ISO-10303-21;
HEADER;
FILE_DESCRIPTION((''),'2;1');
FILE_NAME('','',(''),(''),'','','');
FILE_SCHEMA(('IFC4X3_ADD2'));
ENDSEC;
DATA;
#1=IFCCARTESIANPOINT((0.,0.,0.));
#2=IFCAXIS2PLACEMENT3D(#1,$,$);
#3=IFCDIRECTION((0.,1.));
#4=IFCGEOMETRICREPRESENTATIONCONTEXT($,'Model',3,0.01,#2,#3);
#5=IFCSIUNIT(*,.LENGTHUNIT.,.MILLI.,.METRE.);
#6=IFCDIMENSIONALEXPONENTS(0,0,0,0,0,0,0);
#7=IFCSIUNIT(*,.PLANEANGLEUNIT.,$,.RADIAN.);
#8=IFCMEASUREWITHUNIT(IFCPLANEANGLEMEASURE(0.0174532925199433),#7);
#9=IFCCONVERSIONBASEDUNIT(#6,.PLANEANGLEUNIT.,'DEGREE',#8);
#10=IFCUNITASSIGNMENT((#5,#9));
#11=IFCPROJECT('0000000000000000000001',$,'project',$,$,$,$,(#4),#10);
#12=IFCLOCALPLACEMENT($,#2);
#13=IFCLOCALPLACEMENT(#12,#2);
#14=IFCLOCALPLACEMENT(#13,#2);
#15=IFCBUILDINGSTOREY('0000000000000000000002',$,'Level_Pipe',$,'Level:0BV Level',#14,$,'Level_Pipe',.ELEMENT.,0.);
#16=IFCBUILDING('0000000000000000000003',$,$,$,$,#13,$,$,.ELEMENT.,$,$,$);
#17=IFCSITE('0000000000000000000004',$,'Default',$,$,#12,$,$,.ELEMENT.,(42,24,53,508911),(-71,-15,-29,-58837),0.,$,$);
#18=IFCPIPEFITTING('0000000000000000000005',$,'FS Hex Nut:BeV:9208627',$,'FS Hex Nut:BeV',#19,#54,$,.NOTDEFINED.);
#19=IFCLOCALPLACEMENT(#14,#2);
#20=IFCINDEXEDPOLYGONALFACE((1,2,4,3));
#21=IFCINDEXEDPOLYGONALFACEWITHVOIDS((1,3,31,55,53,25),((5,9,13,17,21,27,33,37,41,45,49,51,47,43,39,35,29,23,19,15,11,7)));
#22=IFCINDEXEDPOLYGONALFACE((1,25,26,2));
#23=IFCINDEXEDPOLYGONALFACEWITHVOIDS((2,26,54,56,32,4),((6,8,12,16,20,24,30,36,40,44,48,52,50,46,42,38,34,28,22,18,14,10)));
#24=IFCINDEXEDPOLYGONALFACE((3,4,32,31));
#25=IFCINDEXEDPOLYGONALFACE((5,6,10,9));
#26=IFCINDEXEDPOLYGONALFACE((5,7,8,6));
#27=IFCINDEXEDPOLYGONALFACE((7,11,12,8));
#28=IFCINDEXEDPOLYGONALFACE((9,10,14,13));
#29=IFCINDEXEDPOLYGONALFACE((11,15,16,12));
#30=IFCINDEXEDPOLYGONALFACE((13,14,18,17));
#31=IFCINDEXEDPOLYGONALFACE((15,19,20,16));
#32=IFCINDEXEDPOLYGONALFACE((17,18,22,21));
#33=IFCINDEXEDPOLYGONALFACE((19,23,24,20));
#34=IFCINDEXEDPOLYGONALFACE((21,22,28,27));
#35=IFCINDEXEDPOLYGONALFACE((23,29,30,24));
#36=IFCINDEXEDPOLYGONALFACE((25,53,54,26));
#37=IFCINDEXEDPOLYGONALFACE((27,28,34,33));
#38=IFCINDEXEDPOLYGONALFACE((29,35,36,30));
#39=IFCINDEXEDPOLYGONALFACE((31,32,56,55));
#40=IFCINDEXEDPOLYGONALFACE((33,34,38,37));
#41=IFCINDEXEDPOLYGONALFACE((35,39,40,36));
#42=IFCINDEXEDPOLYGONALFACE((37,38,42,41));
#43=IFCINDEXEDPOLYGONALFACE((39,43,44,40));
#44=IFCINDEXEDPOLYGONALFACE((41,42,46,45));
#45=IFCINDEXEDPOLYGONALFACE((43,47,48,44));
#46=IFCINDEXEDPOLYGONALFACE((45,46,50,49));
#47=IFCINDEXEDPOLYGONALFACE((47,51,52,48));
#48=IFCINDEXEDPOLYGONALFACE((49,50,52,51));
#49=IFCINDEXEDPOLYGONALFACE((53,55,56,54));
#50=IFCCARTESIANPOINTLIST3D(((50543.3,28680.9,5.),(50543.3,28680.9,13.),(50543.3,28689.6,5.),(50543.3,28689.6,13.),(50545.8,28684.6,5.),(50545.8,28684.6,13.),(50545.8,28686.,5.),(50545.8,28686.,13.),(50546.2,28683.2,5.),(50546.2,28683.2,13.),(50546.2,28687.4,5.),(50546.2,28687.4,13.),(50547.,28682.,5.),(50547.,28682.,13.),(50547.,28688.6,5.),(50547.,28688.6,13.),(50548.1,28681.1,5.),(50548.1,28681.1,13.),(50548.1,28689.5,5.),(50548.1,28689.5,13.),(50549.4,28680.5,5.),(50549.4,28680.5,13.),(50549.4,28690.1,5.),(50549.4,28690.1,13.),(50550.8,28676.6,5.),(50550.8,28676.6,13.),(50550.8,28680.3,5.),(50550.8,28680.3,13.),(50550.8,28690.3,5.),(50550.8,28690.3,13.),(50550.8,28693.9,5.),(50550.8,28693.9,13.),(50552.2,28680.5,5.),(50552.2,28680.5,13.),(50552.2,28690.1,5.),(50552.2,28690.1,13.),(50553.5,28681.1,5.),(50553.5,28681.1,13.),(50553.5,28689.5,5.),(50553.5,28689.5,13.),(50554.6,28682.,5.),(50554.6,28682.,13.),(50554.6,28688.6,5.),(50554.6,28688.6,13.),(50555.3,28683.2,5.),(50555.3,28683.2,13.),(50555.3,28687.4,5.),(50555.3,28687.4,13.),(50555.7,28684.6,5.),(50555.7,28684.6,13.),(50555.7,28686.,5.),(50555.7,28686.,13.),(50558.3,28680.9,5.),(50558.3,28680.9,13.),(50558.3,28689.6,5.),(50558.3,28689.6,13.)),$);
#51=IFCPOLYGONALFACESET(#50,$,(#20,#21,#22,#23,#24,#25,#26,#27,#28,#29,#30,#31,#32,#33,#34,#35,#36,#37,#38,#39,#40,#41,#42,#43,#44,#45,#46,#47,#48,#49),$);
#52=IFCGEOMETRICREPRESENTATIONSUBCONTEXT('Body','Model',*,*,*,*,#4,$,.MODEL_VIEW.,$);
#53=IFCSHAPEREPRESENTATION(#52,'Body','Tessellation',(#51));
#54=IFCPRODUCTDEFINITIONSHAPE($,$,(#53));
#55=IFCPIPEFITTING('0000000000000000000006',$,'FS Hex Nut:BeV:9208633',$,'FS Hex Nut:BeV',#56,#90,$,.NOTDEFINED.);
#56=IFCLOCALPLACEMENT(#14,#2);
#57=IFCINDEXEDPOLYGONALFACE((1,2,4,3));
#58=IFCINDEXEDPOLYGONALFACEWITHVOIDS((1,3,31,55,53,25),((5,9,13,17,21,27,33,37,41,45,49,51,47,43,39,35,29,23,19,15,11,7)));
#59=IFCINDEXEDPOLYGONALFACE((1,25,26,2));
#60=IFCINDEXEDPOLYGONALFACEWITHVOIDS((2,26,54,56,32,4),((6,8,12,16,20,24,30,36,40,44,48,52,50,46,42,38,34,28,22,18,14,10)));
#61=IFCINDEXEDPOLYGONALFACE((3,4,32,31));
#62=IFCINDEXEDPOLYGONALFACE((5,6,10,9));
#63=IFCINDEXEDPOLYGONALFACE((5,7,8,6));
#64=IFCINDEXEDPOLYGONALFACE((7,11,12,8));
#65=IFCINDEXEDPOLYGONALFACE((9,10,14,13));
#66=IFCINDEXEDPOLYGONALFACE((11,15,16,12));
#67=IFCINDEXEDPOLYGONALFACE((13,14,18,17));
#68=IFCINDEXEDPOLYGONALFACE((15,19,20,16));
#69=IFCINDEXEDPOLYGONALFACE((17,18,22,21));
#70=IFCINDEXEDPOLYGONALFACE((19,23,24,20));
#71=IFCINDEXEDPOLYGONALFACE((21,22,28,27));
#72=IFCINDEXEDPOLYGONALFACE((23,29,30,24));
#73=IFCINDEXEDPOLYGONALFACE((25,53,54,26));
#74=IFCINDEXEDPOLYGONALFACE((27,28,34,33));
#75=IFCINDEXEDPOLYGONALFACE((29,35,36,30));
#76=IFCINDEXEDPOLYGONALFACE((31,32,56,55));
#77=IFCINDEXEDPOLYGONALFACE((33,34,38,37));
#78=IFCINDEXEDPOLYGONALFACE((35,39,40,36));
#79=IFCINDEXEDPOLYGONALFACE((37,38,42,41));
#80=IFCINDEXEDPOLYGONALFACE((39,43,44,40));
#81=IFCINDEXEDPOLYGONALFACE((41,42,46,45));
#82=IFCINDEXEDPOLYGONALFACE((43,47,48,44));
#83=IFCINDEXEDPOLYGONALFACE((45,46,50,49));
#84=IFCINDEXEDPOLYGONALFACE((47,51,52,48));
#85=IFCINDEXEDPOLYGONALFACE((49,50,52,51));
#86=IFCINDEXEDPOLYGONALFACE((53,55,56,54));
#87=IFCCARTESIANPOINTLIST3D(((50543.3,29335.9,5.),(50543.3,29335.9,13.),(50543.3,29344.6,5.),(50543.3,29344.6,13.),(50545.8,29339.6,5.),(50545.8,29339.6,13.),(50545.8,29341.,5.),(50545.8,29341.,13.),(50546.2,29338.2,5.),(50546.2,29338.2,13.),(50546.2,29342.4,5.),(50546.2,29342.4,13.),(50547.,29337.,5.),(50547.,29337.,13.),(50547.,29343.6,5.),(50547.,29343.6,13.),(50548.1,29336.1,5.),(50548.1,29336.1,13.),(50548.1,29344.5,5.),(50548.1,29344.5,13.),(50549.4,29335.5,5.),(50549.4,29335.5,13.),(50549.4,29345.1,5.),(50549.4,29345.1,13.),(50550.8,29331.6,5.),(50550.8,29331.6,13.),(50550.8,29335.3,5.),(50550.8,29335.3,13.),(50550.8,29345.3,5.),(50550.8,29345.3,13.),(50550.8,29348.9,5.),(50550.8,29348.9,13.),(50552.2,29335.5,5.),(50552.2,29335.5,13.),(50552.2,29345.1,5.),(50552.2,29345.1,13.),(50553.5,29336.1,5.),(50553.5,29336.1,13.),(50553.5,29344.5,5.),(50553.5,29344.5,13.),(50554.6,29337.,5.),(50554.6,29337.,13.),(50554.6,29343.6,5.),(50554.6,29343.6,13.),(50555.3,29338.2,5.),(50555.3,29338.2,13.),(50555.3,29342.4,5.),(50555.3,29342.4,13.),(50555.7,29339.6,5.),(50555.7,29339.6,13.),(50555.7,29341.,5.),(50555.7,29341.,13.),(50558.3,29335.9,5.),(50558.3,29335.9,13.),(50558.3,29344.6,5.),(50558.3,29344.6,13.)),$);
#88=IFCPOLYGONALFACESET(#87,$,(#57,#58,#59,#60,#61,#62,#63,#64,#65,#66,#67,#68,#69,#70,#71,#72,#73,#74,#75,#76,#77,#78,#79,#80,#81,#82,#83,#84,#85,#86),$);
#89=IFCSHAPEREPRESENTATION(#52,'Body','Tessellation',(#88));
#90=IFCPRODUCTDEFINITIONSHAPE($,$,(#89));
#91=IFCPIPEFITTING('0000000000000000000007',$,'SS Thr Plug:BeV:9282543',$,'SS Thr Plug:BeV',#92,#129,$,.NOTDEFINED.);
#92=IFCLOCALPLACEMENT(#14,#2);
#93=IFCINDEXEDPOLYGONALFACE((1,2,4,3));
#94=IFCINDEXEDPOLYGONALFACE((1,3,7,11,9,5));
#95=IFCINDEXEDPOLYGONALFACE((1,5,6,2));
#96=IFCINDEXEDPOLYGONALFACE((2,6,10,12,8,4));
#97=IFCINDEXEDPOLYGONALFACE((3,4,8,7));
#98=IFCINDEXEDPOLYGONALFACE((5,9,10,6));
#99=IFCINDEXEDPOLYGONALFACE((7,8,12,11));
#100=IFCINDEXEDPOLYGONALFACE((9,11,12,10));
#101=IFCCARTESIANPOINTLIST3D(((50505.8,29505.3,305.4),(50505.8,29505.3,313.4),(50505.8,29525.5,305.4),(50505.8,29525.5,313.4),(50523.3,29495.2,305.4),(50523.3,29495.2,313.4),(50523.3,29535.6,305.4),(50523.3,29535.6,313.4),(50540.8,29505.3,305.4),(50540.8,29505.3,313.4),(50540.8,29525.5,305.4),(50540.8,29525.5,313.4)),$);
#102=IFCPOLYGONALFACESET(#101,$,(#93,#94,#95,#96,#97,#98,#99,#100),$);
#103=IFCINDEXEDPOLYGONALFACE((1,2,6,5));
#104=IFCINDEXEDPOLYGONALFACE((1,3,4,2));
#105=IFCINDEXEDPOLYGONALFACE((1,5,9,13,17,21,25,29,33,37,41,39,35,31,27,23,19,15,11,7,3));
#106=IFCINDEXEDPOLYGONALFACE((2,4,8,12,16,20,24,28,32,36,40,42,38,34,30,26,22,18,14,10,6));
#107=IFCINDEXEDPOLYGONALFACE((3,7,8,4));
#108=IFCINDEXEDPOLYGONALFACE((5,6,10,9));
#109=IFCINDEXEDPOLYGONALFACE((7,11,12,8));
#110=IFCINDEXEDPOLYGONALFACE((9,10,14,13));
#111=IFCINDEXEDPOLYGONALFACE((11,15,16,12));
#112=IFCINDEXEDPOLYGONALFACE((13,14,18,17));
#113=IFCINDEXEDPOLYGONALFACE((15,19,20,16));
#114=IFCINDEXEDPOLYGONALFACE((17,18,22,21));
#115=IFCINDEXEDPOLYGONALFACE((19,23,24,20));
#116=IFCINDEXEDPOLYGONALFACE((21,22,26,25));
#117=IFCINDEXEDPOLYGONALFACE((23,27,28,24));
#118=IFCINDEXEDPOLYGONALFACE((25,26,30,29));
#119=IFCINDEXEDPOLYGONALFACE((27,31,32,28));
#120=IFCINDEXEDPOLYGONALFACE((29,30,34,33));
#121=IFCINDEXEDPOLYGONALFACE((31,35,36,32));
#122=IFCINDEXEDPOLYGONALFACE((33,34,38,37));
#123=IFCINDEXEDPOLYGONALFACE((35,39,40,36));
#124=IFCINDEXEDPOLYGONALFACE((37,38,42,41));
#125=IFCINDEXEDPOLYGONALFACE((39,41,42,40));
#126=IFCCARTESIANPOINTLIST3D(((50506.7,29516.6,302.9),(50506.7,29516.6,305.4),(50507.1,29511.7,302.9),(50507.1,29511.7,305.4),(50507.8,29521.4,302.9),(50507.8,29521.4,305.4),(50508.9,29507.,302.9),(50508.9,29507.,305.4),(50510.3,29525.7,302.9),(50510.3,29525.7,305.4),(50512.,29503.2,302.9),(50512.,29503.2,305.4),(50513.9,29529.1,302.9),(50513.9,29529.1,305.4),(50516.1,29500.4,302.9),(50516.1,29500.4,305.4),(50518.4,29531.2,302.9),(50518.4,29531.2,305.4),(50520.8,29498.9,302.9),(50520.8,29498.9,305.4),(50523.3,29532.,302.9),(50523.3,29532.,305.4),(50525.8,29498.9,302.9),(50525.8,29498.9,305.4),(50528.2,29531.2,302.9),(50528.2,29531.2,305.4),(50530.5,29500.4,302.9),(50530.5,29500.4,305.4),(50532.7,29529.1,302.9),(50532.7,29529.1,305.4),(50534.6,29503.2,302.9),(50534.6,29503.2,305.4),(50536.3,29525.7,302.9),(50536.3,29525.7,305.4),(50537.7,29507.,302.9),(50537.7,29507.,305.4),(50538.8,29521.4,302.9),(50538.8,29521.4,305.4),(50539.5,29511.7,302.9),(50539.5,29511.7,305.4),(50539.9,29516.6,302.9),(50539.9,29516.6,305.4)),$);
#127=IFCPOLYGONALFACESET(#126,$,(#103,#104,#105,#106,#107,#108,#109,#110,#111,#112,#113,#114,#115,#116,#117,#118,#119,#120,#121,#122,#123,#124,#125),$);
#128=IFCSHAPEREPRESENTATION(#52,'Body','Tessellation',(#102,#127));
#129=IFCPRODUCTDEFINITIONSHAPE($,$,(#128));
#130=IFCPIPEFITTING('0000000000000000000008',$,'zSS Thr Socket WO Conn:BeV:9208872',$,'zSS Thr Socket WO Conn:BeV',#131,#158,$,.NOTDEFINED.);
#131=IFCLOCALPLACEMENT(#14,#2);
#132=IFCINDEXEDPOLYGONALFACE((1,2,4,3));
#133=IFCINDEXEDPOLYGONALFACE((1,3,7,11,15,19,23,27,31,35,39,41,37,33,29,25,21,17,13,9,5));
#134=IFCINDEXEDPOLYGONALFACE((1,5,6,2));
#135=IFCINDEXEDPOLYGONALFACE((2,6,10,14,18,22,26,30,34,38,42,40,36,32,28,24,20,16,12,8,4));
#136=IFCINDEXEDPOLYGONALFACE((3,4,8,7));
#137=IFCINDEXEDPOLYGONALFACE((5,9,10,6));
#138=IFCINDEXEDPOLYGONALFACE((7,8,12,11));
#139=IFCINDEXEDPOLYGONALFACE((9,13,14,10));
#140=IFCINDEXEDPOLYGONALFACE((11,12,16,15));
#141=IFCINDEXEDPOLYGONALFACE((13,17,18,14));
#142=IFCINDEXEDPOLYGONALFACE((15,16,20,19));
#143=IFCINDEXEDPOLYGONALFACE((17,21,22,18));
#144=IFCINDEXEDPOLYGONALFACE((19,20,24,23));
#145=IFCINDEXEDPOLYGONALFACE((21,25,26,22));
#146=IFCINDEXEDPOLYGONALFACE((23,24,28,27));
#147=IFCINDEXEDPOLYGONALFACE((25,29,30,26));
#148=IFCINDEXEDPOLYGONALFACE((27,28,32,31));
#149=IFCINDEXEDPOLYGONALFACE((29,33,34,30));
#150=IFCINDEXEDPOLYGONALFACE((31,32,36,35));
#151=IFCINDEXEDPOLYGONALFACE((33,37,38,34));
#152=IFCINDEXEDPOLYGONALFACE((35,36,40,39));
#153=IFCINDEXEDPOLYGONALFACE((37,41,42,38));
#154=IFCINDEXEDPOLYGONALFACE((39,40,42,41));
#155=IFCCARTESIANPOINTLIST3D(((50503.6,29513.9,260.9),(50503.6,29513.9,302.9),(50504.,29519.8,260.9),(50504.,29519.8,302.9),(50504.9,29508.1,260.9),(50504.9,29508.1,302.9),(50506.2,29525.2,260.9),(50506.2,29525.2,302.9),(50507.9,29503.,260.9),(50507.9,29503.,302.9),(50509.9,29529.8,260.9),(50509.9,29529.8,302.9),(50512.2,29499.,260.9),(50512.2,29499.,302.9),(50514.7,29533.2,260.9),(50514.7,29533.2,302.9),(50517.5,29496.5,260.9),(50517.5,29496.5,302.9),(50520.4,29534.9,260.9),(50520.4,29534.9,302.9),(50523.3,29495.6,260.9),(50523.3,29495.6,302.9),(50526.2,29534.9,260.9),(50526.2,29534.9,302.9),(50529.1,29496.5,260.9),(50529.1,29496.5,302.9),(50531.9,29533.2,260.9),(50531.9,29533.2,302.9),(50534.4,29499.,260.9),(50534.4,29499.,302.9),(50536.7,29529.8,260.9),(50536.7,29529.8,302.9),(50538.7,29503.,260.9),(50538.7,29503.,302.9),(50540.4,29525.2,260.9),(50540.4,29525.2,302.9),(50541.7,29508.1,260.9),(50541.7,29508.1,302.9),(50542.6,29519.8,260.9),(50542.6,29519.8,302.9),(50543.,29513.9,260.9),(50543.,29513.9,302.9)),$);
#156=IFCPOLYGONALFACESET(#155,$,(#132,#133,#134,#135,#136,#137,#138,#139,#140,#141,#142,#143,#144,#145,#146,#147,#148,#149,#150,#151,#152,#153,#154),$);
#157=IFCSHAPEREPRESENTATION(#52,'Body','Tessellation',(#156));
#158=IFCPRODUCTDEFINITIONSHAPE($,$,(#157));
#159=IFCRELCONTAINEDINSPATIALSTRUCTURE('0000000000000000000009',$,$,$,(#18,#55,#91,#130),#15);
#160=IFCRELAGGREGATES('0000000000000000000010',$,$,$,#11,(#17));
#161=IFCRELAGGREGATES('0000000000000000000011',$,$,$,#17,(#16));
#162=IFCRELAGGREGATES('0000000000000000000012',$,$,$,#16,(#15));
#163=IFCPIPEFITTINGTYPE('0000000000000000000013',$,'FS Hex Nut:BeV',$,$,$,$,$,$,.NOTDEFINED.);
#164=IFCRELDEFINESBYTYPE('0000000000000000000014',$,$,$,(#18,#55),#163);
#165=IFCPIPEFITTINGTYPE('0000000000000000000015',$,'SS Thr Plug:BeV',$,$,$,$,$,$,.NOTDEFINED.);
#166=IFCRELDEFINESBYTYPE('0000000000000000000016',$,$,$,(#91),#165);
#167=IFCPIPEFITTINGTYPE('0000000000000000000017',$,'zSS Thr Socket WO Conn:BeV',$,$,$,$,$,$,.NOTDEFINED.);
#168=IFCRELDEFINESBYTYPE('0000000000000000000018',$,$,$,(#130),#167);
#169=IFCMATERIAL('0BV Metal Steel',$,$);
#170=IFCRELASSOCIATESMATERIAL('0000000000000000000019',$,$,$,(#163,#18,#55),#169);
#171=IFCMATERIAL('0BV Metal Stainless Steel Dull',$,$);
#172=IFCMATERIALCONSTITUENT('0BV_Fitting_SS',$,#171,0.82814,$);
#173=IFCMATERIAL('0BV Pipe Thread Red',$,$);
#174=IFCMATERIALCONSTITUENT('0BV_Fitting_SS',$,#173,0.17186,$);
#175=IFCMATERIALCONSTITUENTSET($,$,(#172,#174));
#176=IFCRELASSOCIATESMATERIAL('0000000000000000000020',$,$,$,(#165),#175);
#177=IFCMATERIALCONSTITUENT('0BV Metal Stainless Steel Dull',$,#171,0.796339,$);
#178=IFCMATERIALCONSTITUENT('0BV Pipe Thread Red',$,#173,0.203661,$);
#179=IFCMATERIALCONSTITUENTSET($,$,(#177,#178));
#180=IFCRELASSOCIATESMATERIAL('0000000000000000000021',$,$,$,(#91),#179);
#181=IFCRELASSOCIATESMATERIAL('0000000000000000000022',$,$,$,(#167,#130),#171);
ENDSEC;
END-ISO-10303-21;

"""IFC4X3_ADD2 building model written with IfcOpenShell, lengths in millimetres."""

from ifc_helpers import new_model, entity, si_unit, converted_unit, direction, frame, frame_2d, origin, place, context, subcontext, project, spatial, polyline, circle_curve, parameter, trimmed, segment, composite_curve, circle, outline, extrude, source, transform, mapped, material, constituent, constituent_set, type_object, type_shapes, element, save


model = new_model("IFC4X3_ADD2")

# Units and contexts
model_context = context("Model", 3, precision=0.01, world=origin(), true_north=direction((0.0, 1.0)))
body_context = subcontext(model_context, "Body", "Model", "MODEL_VIEW")
ifc_project = project(units=[si_unit("LENGTHUNIT", "METRE", prefix="MILLI"), converted_unit("PLANEANGLEUNIT", "DEGREE", entity("IfcPlaneAngleMeasure", 0.0174532925199433), si_unit("PLANEANGLEUNIT", "RADIAN"), dimensions=[0, 0, 0, 0, 0, 0, 0])], contexts=[model_context])

# Site, building, storey
site_placement = place(None, origin())
site = spatial("IfcSite", under=ifc_project, at=site_placement, Name="Default", CompositionType="ELEMENT", RefLatitude=(42, 24, 53, 508911), RefLongitude=(-71, -15, -29, -58837), RefElevation=0.0)
building_placement = place(site_placement, origin())
building = spatial("IfcBuilding", under=site, at=building_placement, CompositionType="ELEMENT")
storey_placement = place(building_placement, origin())
storey = spatial("IfcBuildingStorey", under=building, at=storey_placement, Name="Level_Pipe", ObjectType="Level:0BV Level", LongName="Level_Pipe", CompositionType="ELEMENT", Elevation=0.0)

# Pipe fittings
ifc_material_1 = material(Name="0BV Metal Stainless Steel Dull")
ifc_material_2 = material(Name="0BV Metal Steel")
ifc_material_3 = material(Name="0BV Pipe Thread Red")
pipe_fitting_type_1 = type_object("IfcPipeFittingType", Name="FS Hex Nut:BeV", PredefinedType="NOTDEFINED", material=ifc_material_2)
shared_shape_1 = source(origin(), body_context, "Body", "SweptSolid", [
    extrude(outline(polyline([(-4.3, -7.5), (4.3, -7.5), (8.7, 0.0), (4.3, 7.5), (-4.3, 7.5), (-8.7, 0.0), (-4.3, -7.5)]), holes=[composite_curve([segment(trimmed(circle_curve(frame_2d((0.0, 0.0), x_axis=(-0.5, 0.866025)), 5.0), [parameter(0.0)], [parameter(180.0)], True, "PARAMETER"), False, "CONTINUOUS"), segment(trimmed(circle_curve(frame_2d((0.0, 0.0), x_axis=(-0.5, 0.866025)), 5.0), [parameter(180.0)], [parameter(360.0)], True, "PARAMETER"), False, "CONTINUOUS")], self_intersect=False)]), frame((0.0, 8.7, 7.5), z_axis=(1.0, 0.0, 0.0), x_axis=(0.0, -0.5, -0.866025)), (0.0, 0.0, 1.0), 8.0),
])
type_shapes(pipe_fitting_type_1, [shared_shape_1])
for number, where, z_axis, x_axis, name in (
    (1, (50558.3, 28693.9, 13.0), (-1.0, 0.0, 0.0), (0.0, 0.0, -1.0), "FS Hex Nut:BeV:9208627"),
    (2, (50558.3, 29348.9, 13.0), (-1.0, 0.0, 0.0), (0.0, 0.0, -1.0), "FS Hex Nut:BeV:9208633"),
):
    element("IfcPipeFitting", number, at=place(storey_placement, frame(where, z_axis=z_axis, x_axis=x_axis)), inside=storey, type_object=pipe_fitting_type_1, material=ifc_material_2, Name=name, ObjectType="FS Hex Nut:BeV", PredefinedType="NOTDEFINED", context=body_context, shape_type="MappedRepresentation", body=[
        mapped(shared_shape_1, transform((0.0, 0.0, 0.0), scale=1.0)),
    ])
ifc_constituent_1 = constituent(ifc_material_1, Name="0BV Metal Stainless Steel Dull", fraction=0.796339)
ifc_constituent_2 = constituent(ifc_material_3, Name="0BV Pipe Thread Red", fraction=0.203661)
ifc_constituent_set_1 = constituent_set(constituents=[ifc_constituent_1, ifc_constituent_2])
ifc_constituent_3 = constituent(ifc_material_1, Name="0BV_Fitting_SS", fraction=0.82814)
ifc_constituent_4 = constituent(ifc_material_3, Name="0BV_Fitting_SS", fraction=0.17186)
ifc_constituent_set_2 = constituent_set(constituents=[ifc_constituent_3, ifc_constituent_4])
pipe_fitting_type_2 = type_object("IfcPipeFittingType", Name="SS Thr Plug:BeV", PredefinedType="NOTDEFINED", material=ifc_constituent_set_2)
shared_shape_2 = source(origin(), body_context, "Body", "SweptSolid", [
    extrude(outline(polyline([(-10.1, -17.5), (10.1, -17.5), (20.2, 0.0), (10.1, 17.5), (-10.1, 17.5), (-20.2, 0.0), (-10.1, -17.5)])), frame((2.5, 0.0, 0.0), z_axis=(1.0, 0.0, 0.0), x_axis=(0.0, -0.5, -0.866025)), (0.0, 0.0, 1.0), 8.0),
    extrude(circle(Radius=16.6, at=frame_2d((0.0, 0.0), x_axis=(1.0, 0.0))), frame((0.0, 0.0, 0.0), z_axis=(1.0, 0.0, 0.0), x_axis=(0.0, 1.0, 0.0)), (0.0, 0.0, 1.0), 2.5),
])
type_shapes(pipe_fitting_type_2, [shared_shape_2])
pipe_fitting_1_placement = place(storey_placement, frame((50523.3, 29515.4, 302.9), z_axis=(-1.0, 0.0, 0.0), x_axis=(0.0, 0.0, 1.0)))
element("IfcPipeFitting", 3, at=pipe_fitting_1_placement, inside=storey, type_object=pipe_fitting_type_2, material=ifc_constituent_set_1, Name="SS Thr Plug:BeV:9282543", ObjectType="SS Thr Plug:BeV", PredefinedType="NOTDEFINED", context=body_context, shape_type="MappedRepresentation", body=[
    mapped(shared_shape_2, transform((0.0, 0.0, 0.0), scale=1.0)),
])
pipe_fitting_type_3 = type_object("IfcPipeFittingType", Name="zSS Thr Socket WO Conn:BeV", PredefinedType="NOTDEFINED", material=ifc_material_1)
shared_shape_3 = source(origin(), body_context, "Body", "SweptSolid", [
    extrude(circle(Radius=19.8, at=frame_2d((0.0, 0.0), x_axis=(1.0, 0.0))), frame((-21.0, 0.0, 0.0), z_axis=(1.0, 0.0, 0.0), x_axis=(0.0, 1.0, 0.0)), (0.0, 0.0, 1.0), 42.0),
])
type_shapes(pipe_fitting_type_3, [shared_shape_3])
pipe_fitting_2_placement = place(storey_placement, frame((50523.3, 29515.4, 281.9), z_axis=(-1.0, 0.0, 0.0), x_axis=(0.0, 0.0, -1.0)))
element("IfcPipeFitting", 4, at=pipe_fitting_2_placement, inside=storey, type_object=pipe_fitting_type_3, material=ifc_material_1, Name="zSS Thr Socket WO Conn:BeV:9208872", ObjectType="zSS Thr Socket WO Conn:BeV", PredefinedType="NOTDEFINED", context=body_context, shape_type="MappedRepresentation", body=[
    mapped(shared_shape_3, transform((0.0, 0.0, 0.0), scale=1.0)),
])

save(model, "model.ifc")
